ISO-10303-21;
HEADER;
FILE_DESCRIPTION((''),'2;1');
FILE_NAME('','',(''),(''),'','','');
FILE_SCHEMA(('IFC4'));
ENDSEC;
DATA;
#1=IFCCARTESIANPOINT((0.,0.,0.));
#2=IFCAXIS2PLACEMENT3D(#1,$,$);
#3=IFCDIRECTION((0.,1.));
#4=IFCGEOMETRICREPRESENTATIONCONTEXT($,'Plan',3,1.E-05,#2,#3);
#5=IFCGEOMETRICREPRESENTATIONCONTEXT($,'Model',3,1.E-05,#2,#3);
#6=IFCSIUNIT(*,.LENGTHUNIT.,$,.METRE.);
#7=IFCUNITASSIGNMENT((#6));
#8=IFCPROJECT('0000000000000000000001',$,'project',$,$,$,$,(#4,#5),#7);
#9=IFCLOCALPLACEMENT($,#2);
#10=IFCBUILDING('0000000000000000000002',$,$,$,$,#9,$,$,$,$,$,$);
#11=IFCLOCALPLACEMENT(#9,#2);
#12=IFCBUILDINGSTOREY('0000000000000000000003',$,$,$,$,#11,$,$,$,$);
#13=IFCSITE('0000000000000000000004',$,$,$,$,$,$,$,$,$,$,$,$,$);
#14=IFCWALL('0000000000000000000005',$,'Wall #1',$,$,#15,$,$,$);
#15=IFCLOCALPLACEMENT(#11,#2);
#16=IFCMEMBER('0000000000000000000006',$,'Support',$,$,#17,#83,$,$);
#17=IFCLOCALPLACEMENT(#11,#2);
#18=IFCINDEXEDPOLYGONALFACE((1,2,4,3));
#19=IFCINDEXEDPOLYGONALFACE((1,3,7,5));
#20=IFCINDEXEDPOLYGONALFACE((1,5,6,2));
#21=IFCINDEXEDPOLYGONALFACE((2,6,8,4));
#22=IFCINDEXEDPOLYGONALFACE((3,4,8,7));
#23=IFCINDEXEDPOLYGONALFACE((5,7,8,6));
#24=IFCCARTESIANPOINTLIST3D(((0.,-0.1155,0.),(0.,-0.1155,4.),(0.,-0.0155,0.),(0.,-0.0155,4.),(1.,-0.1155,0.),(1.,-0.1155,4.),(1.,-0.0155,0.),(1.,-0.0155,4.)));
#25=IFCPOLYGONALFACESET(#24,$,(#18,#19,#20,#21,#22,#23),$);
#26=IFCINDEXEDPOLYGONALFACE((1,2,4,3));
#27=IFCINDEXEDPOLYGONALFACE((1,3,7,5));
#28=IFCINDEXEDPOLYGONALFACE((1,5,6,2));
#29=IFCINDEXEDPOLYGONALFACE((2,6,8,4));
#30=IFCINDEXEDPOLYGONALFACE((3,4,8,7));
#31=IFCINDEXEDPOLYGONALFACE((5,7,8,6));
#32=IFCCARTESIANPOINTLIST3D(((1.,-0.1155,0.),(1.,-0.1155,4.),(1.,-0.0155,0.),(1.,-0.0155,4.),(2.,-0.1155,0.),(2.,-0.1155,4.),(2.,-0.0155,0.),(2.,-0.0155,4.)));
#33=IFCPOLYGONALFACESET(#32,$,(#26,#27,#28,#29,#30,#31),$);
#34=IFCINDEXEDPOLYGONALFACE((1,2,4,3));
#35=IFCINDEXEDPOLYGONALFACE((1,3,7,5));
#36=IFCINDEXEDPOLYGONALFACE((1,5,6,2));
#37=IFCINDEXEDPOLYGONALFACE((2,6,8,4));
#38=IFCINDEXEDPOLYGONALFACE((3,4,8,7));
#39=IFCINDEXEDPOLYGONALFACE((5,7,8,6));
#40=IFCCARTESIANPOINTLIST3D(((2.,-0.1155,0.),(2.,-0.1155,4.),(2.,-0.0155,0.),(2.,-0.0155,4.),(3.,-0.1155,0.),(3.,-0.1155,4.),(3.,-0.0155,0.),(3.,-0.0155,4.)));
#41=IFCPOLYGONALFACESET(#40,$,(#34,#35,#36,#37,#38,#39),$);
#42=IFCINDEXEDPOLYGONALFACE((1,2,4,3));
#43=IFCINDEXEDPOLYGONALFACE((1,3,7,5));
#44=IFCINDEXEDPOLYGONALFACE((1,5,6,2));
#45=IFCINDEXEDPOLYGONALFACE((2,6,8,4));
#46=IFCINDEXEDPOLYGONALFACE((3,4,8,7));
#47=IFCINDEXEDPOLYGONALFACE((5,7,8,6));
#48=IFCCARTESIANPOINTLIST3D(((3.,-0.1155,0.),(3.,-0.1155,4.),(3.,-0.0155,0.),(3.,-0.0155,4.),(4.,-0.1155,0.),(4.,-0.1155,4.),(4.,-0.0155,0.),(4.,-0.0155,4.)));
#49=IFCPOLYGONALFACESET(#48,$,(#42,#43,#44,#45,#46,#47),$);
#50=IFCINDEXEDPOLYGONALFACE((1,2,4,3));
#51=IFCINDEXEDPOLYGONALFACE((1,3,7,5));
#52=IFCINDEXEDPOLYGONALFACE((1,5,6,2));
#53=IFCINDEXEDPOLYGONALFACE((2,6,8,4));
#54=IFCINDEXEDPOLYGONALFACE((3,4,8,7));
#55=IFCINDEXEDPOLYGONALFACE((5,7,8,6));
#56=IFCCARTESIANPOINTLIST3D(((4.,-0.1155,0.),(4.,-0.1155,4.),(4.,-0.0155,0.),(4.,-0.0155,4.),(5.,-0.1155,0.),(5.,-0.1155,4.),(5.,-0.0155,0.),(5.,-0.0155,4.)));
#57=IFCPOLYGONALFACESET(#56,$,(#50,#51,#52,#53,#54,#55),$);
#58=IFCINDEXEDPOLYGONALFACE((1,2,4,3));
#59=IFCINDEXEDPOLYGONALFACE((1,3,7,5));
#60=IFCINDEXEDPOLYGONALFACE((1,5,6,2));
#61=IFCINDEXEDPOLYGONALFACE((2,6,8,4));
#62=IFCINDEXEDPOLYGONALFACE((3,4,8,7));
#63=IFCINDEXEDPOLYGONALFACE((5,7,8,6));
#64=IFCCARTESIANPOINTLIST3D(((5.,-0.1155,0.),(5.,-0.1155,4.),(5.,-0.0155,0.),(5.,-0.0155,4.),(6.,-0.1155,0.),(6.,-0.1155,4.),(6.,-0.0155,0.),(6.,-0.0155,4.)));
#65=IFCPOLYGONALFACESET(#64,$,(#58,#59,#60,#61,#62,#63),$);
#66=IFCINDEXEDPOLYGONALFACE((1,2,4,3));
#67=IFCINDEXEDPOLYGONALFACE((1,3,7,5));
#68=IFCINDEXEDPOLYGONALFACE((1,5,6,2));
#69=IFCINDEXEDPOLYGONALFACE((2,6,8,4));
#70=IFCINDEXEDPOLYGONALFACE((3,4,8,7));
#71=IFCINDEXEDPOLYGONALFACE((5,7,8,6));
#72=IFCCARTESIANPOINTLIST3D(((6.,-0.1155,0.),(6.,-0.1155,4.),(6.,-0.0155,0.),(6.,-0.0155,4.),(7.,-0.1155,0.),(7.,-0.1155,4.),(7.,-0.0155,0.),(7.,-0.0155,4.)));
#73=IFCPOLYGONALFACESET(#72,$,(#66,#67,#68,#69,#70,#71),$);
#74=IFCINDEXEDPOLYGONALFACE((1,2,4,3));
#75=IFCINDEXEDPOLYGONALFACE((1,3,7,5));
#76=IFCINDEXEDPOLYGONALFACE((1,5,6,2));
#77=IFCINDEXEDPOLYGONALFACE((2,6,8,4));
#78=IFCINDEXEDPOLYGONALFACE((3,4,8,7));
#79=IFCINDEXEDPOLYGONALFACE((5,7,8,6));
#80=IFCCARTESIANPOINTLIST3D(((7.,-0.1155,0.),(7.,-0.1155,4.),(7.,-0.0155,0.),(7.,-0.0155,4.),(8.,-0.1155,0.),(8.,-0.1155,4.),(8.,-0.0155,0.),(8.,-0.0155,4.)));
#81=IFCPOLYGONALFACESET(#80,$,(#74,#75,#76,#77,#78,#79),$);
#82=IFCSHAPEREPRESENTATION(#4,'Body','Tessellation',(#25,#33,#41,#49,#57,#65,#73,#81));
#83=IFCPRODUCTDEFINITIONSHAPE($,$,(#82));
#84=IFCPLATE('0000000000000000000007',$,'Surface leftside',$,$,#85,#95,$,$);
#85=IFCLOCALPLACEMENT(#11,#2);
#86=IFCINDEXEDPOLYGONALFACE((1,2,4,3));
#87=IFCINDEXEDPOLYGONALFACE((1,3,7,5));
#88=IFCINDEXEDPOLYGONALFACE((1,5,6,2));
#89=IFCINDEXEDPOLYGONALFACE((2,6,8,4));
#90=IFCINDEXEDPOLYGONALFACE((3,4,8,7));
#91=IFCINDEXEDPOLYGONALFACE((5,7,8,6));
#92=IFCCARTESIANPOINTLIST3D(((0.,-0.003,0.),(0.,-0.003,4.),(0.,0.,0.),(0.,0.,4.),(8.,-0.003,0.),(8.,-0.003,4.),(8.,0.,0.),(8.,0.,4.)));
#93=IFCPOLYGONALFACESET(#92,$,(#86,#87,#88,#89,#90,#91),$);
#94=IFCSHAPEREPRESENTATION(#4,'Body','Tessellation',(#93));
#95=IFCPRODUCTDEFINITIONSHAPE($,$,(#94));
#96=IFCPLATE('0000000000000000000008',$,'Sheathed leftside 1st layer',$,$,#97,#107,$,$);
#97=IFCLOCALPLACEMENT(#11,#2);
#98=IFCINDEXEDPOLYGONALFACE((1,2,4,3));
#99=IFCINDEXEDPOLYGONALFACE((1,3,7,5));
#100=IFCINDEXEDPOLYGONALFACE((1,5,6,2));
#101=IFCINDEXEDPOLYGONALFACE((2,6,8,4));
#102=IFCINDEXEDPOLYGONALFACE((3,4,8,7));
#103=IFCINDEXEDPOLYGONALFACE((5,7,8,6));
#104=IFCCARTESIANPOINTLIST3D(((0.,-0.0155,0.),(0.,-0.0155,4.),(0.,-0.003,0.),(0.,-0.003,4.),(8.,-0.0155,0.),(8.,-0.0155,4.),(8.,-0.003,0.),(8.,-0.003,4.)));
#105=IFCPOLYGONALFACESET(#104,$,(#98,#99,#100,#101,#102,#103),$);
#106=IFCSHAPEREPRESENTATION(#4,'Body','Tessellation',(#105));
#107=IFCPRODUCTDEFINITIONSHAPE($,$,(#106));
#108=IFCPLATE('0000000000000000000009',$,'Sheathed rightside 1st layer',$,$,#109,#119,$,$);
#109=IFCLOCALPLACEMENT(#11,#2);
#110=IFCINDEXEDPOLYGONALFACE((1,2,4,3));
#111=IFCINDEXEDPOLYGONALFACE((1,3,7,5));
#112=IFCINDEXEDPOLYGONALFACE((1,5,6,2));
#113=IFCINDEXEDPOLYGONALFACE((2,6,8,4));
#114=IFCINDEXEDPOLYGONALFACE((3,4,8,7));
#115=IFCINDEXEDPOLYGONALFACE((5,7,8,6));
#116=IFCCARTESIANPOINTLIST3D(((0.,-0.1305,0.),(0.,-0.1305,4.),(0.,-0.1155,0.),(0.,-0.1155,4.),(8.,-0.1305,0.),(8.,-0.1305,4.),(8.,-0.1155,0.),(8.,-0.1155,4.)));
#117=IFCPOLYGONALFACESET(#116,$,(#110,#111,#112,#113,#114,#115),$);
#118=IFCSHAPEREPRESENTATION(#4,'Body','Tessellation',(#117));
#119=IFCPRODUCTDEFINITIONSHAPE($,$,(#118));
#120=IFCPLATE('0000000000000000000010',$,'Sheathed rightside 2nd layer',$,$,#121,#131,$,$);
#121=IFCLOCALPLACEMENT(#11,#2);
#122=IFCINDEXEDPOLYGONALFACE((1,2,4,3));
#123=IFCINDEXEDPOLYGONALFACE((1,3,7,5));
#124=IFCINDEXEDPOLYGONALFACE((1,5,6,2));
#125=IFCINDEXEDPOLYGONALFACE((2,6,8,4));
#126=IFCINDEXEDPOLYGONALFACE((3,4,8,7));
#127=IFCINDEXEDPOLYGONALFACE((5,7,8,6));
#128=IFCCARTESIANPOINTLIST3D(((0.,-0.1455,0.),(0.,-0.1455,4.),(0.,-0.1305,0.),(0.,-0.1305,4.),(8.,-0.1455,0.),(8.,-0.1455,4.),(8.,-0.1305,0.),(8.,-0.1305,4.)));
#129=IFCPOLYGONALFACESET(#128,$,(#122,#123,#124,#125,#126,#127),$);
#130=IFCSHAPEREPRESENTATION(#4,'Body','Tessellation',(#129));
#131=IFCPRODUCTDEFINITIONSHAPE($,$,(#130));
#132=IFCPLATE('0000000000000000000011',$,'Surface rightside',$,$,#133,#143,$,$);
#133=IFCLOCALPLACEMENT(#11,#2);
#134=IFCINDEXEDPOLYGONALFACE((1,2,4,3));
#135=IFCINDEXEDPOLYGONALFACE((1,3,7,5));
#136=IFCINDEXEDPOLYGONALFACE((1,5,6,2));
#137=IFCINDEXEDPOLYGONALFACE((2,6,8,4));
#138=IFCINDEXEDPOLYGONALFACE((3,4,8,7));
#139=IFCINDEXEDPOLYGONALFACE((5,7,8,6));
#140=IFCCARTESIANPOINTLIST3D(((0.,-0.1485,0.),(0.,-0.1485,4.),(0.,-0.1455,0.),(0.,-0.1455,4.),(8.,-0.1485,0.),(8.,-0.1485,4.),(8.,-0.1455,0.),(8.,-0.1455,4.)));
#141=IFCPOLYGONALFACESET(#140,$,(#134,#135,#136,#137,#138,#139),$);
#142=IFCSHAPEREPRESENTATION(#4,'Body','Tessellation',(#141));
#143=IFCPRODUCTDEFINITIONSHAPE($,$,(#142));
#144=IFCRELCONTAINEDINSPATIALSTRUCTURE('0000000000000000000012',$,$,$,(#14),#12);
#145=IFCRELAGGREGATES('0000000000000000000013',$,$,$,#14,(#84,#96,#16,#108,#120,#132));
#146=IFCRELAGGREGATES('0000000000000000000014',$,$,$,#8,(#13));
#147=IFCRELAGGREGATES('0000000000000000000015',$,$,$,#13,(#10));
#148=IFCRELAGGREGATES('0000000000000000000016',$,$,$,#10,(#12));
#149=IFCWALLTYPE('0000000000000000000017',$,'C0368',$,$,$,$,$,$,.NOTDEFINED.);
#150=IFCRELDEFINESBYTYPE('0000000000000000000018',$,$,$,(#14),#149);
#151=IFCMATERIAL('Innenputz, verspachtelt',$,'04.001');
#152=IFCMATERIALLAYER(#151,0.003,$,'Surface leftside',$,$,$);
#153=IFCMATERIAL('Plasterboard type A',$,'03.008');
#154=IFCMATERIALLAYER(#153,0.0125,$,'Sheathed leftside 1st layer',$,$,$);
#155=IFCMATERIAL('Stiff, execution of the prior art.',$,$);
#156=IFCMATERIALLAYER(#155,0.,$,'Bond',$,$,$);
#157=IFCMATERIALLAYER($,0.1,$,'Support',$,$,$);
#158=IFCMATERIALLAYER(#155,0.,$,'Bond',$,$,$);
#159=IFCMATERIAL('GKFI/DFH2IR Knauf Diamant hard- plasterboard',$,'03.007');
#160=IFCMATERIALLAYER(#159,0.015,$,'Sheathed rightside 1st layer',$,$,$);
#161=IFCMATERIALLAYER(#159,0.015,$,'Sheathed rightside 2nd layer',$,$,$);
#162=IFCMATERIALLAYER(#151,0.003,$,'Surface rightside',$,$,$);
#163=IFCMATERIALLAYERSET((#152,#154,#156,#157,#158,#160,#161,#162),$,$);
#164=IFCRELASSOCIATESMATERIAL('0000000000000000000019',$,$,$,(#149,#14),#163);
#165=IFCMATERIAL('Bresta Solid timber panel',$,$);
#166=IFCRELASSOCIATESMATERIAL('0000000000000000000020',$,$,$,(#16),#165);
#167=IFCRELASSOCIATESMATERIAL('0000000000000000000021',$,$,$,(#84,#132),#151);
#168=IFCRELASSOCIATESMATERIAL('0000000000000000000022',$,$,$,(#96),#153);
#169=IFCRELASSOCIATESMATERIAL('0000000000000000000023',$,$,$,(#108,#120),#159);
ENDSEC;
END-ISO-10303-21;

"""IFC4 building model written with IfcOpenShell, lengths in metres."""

from ifc_helpers import new_model, si_unit, direction, frame, frame_2d, origin, origin_with_axes, place, context, project, spatial, rectangle, extrude, material, layer, layer_set, type_object, element, aggregate, save


model = new_model("IFC4")

# Units and contexts
plan_context = context("Plan", 3, precision=1e-05, world=origin(), true_north=direction((0.0, 1.0)))
model_context = context("Model", 3, precision=1e-05, world=origin(), true_north=direction((0.0, 1.0)))
ifc_project = project(units=[si_unit("LENGTHUNIT", "METRE")], contexts=[plan_context, model_context])

# Site, building, storey
site = spatial("IfcSite", under=ifc_project)
building_placement = place(None, origin())
building = spatial("IfcBuilding", under=site, at=building_placement)
storey_placement = place(building_placement, origin())
storey = spatial("IfcBuildingStorey", under=building, at=storey_placement)

# Wall, member, plates
ifc_material_1 = material(Name="Innenputz, verspachtelt", Category="04.001")
ifc_layer_1 = layer(ifc_material_1, 0.003, Name="Surface leftside")
ifc_material_2 = material(Name="Plasterboard type A", Category="03.008")
ifc_layer_2 = layer(ifc_material_2, 0.0125, Name="Sheathed leftside 1st layer")
ifc_material_3 = material(Name="Stiff, execution of the prior art.")
ifc_layer_3 = layer(ifc_material_3, 0.0, Name="Bond")
ifc_layer_4 = layer(None, 0.1, Name="Support")
ifc_layer_5 = layer(ifc_material_3, 0.0, Name="Bond")
ifc_material_4 = material(Name="GKFI/DFH2IR Knauf Diamant hard- plasterboard", Category="03.007")
ifc_layer_6 = layer(ifc_material_4, 0.015, Name="Sheathed rightside 1st layer")
ifc_layer_7 = layer(ifc_material_4, 0.015, Name="Sheathed rightside 2nd layer")
ifc_layer_8 = layer(ifc_material_1, 0.003, Name="Surface rightside")
ifc_layer_set = layer_set([ifc_layer_1, ifc_layer_2, ifc_layer_3, ifc_layer_4, ifc_layer_5, ifc_layer_6, ifc_layer_7, ifc_layer_8])
wall_type = type_object("IfcWallType", Name="C0368", PredefinedType="NOTDEFINED", material=ifc_layer_set)
wall_placement = place(None, frame((0.0, 0.0, 0.0), z_axis=(0.0, -1.0, 0.0), x_axis=(1.0, 0.0, 0.0)))
wall = element("IfcWall", 1, at=wall_placement, inside=storey, type_object=wall_type, material=ifc_layer_set, Name="Wall #1")
ifc_material_5 = material(Name="Bresta Solid timber panel")
member_placement = place(wall_placement, origin())
member = element("IfcMember", 2, at=member_placement, material=ifc_material_5, Name="Support", context=plan_context, shape_type="SweptSolid", body=[
    extrude(rectangle(XDim=1.0, YDim=0.1, at=frame_2d((0.5, 0.05), x_axis=(1.0, 0.0))), frame((0.0, 4.0, 0.0155), z_axis=(0.0, -1.0, 0.0), x_axis=(1.0, 0.0, 0.0)), (0.0, 0.0, 1.0), 4.0),
    extrude(rectangle(XDim=1.0, YDim=0.1, at=frame_2d((0.5, 0.05), x_axis=(1.0, 0.0))), frame((1.0, 4.0, 0.0155), z_axis=(0.0, -1.0, 0.0), x_axis=(1.0, 0.0, 0.0)), (0.0, 0.0, 1.0), 4.0),
    extrude(rectangle(XDim=1.0, YDim=0.1, at=frame_2d((0.5, 0.05), x_axis=(1.0, 0.0))), frame((2.0, 4.0, 0.0155), z_axis=(0.0, -1.0, 0.0), x_axis=(1.0, 0.0, 0.0)), (0.0, 0.0, 1.0), 4.0),
    extrude(rectangle(XDim=1.0, YDim=0.1, at=frame_2d((0.5, 0.05), x_axis=(1.0, 0.0))), frame((3.0, 4.0, 0.0155), z_axis=(0.0, -1.0, 0.0), x_axis=(1.0, 0.0, 0.0)), (0.0, 0.0, 1.0), 4.0),
    extrude(rectangle(XDim=1.0, YDim=0.1, at=frame_2d((0.5, 0.05), x_axis=(1.0, 0.0))), frame((4.0, 4.0, 0.0155), z_axis=(0.0, -1.0, 0.0), x_axis=(1.0, 0.0, 0.0)), (0.0, 0.0, 1.0), 4.0),
    extrude(rectangle(XDim=1.0, YDim=0.1, at=frame_2d((0.5, 0.05), x_axis=(1.0, 0.0))), frame((5.0, 4.0, 0.0155), z_axis=(0.0, -1.0, 0.0), x_axis=(1.0, 0.0, 0.0)), (0.0, 0.0, 1.0), 4.0),
    extrude(rectangle(XDim=1.0, YDim=0.1, at=frame_2d((0.5, 0.05), x_axis=(1.0, 0.0))), frame((6.0, 4.0, 0.0155), z_axis=(0.0, -1.0, 0.0), x_axis=(1.0, 0.0, 0.0)), (0.0, 0.0, 1.0), 4.0),
    extrude(rectangle(XDim=1.0, YDim=0.1, at=frame_2d((0.5, 0.05), x_axis=(1.0, 0.0))), frame((7.0, 4.0, 0.0155), z_axis=(0.0, -1.0, 0.0), x_axis=(1.0, 0.0, 0.0)), (0.0, 0.0, 1.0), 4.0),
])
plate_1_placement = place(wall_placement, origin())
plate_1 = element("IfcPlate", 3, at=plate_1_placement, material=ifc_material_1, Name="Surface leftside", context=plan_context, shape_type="SweptSolid", body=[
    extrude(rectangle(XDim=8.0, YDim=4.0, at=frame_2d((4.0, 2.0), x_axis=(1.0, 0.0))), origin_with_axes(), (0.0, 0.0, 1.0), 0.003),
])
plate_2_placement = place(wall_placement, origin())
plate_2 = element("IfcPlate", 4, at=plate_2_placement, material=ifc_material_2, Name="Sheathed leftside 1st layer", context=plan_context, shape_type="SweptSolid", body=[
    extrude(rectangle(XDim=8.0, YDim=4.0, at=frame_2d((4.0, 2.0), x_axis=(1.0, 0.0))), frame((0.0, 0.0, 0.003), z_axis=(0.0, 0.0, 1.0), x_axis=(1.0, 0.0, 0.0)), (0.0, 0.0, 1.0), 0.0125),
])
plate_3_placement = place(wall_placement, origin())
plate_3 = element("IfcPlate", 5, at=plate_3_placement, material=ifc_material_4, Name="Sheathed rightside 1st layer", context=plan_context, shape_type="SweptSolid", body=[
    extrude(rectangle(XDim=8.0, YDim=4.0, at=frame_2d((4.0, 2.0), x_axis=(1.0, 0.0))), frame((0.0, 0.0, 0.1155), z_axis=(0.0, 0.0, 1.0), x_axis=(1.0, 0.0, 0.0)), (0.0, 0.0, 1.0), 0.015),
])
plate_4_placement = place(wall_placement, origin())
plate_4 = element("IfcPlate", 6, at=plate_4_placement, material=ifc_material_4, Name="Sheathed rightside 2nd layer", context=plan_context, shape_type="SweptSolid", body=[
    extrude(rectangle(XDim=8.0, YDim=4.0, at=frame_2d((4.0, 2.0), x_axis=(1.0, 0.0))), frame((0.0, 0.0, 0.1305), z_axis=(0.0, 0.0, 1.0), x_axis=(1.0, 0.0, 0.0)), (0.0, 0.0, 1.0), 0.015),
])
plate_5_placement = place(wall_placement, origin())
plate_5 = element("IfcPlate", 7, at=plate_5_placement, material=ifc_material_1, Name="Surface rightside", context=plan_context, shape_type="SweptSolid", body=[
    extrude(rectangle(XDim=8.0, YDim=4.0, at=frame_2d((4.0, 2.0), x_axis=(1.0, 0.0))), frame((0.0, 0.0, 0.1455), z_axis=(0.0, 0.0, 1.0), x_axis=(1.0, 0.0, 0.0)), (0.0, 0.0, 1.0), 0.003),
])
aggregate(wall, [plate_1, plate_2, member, plate_3, plate_4, plate_5])

save(model, "model.ifc")
